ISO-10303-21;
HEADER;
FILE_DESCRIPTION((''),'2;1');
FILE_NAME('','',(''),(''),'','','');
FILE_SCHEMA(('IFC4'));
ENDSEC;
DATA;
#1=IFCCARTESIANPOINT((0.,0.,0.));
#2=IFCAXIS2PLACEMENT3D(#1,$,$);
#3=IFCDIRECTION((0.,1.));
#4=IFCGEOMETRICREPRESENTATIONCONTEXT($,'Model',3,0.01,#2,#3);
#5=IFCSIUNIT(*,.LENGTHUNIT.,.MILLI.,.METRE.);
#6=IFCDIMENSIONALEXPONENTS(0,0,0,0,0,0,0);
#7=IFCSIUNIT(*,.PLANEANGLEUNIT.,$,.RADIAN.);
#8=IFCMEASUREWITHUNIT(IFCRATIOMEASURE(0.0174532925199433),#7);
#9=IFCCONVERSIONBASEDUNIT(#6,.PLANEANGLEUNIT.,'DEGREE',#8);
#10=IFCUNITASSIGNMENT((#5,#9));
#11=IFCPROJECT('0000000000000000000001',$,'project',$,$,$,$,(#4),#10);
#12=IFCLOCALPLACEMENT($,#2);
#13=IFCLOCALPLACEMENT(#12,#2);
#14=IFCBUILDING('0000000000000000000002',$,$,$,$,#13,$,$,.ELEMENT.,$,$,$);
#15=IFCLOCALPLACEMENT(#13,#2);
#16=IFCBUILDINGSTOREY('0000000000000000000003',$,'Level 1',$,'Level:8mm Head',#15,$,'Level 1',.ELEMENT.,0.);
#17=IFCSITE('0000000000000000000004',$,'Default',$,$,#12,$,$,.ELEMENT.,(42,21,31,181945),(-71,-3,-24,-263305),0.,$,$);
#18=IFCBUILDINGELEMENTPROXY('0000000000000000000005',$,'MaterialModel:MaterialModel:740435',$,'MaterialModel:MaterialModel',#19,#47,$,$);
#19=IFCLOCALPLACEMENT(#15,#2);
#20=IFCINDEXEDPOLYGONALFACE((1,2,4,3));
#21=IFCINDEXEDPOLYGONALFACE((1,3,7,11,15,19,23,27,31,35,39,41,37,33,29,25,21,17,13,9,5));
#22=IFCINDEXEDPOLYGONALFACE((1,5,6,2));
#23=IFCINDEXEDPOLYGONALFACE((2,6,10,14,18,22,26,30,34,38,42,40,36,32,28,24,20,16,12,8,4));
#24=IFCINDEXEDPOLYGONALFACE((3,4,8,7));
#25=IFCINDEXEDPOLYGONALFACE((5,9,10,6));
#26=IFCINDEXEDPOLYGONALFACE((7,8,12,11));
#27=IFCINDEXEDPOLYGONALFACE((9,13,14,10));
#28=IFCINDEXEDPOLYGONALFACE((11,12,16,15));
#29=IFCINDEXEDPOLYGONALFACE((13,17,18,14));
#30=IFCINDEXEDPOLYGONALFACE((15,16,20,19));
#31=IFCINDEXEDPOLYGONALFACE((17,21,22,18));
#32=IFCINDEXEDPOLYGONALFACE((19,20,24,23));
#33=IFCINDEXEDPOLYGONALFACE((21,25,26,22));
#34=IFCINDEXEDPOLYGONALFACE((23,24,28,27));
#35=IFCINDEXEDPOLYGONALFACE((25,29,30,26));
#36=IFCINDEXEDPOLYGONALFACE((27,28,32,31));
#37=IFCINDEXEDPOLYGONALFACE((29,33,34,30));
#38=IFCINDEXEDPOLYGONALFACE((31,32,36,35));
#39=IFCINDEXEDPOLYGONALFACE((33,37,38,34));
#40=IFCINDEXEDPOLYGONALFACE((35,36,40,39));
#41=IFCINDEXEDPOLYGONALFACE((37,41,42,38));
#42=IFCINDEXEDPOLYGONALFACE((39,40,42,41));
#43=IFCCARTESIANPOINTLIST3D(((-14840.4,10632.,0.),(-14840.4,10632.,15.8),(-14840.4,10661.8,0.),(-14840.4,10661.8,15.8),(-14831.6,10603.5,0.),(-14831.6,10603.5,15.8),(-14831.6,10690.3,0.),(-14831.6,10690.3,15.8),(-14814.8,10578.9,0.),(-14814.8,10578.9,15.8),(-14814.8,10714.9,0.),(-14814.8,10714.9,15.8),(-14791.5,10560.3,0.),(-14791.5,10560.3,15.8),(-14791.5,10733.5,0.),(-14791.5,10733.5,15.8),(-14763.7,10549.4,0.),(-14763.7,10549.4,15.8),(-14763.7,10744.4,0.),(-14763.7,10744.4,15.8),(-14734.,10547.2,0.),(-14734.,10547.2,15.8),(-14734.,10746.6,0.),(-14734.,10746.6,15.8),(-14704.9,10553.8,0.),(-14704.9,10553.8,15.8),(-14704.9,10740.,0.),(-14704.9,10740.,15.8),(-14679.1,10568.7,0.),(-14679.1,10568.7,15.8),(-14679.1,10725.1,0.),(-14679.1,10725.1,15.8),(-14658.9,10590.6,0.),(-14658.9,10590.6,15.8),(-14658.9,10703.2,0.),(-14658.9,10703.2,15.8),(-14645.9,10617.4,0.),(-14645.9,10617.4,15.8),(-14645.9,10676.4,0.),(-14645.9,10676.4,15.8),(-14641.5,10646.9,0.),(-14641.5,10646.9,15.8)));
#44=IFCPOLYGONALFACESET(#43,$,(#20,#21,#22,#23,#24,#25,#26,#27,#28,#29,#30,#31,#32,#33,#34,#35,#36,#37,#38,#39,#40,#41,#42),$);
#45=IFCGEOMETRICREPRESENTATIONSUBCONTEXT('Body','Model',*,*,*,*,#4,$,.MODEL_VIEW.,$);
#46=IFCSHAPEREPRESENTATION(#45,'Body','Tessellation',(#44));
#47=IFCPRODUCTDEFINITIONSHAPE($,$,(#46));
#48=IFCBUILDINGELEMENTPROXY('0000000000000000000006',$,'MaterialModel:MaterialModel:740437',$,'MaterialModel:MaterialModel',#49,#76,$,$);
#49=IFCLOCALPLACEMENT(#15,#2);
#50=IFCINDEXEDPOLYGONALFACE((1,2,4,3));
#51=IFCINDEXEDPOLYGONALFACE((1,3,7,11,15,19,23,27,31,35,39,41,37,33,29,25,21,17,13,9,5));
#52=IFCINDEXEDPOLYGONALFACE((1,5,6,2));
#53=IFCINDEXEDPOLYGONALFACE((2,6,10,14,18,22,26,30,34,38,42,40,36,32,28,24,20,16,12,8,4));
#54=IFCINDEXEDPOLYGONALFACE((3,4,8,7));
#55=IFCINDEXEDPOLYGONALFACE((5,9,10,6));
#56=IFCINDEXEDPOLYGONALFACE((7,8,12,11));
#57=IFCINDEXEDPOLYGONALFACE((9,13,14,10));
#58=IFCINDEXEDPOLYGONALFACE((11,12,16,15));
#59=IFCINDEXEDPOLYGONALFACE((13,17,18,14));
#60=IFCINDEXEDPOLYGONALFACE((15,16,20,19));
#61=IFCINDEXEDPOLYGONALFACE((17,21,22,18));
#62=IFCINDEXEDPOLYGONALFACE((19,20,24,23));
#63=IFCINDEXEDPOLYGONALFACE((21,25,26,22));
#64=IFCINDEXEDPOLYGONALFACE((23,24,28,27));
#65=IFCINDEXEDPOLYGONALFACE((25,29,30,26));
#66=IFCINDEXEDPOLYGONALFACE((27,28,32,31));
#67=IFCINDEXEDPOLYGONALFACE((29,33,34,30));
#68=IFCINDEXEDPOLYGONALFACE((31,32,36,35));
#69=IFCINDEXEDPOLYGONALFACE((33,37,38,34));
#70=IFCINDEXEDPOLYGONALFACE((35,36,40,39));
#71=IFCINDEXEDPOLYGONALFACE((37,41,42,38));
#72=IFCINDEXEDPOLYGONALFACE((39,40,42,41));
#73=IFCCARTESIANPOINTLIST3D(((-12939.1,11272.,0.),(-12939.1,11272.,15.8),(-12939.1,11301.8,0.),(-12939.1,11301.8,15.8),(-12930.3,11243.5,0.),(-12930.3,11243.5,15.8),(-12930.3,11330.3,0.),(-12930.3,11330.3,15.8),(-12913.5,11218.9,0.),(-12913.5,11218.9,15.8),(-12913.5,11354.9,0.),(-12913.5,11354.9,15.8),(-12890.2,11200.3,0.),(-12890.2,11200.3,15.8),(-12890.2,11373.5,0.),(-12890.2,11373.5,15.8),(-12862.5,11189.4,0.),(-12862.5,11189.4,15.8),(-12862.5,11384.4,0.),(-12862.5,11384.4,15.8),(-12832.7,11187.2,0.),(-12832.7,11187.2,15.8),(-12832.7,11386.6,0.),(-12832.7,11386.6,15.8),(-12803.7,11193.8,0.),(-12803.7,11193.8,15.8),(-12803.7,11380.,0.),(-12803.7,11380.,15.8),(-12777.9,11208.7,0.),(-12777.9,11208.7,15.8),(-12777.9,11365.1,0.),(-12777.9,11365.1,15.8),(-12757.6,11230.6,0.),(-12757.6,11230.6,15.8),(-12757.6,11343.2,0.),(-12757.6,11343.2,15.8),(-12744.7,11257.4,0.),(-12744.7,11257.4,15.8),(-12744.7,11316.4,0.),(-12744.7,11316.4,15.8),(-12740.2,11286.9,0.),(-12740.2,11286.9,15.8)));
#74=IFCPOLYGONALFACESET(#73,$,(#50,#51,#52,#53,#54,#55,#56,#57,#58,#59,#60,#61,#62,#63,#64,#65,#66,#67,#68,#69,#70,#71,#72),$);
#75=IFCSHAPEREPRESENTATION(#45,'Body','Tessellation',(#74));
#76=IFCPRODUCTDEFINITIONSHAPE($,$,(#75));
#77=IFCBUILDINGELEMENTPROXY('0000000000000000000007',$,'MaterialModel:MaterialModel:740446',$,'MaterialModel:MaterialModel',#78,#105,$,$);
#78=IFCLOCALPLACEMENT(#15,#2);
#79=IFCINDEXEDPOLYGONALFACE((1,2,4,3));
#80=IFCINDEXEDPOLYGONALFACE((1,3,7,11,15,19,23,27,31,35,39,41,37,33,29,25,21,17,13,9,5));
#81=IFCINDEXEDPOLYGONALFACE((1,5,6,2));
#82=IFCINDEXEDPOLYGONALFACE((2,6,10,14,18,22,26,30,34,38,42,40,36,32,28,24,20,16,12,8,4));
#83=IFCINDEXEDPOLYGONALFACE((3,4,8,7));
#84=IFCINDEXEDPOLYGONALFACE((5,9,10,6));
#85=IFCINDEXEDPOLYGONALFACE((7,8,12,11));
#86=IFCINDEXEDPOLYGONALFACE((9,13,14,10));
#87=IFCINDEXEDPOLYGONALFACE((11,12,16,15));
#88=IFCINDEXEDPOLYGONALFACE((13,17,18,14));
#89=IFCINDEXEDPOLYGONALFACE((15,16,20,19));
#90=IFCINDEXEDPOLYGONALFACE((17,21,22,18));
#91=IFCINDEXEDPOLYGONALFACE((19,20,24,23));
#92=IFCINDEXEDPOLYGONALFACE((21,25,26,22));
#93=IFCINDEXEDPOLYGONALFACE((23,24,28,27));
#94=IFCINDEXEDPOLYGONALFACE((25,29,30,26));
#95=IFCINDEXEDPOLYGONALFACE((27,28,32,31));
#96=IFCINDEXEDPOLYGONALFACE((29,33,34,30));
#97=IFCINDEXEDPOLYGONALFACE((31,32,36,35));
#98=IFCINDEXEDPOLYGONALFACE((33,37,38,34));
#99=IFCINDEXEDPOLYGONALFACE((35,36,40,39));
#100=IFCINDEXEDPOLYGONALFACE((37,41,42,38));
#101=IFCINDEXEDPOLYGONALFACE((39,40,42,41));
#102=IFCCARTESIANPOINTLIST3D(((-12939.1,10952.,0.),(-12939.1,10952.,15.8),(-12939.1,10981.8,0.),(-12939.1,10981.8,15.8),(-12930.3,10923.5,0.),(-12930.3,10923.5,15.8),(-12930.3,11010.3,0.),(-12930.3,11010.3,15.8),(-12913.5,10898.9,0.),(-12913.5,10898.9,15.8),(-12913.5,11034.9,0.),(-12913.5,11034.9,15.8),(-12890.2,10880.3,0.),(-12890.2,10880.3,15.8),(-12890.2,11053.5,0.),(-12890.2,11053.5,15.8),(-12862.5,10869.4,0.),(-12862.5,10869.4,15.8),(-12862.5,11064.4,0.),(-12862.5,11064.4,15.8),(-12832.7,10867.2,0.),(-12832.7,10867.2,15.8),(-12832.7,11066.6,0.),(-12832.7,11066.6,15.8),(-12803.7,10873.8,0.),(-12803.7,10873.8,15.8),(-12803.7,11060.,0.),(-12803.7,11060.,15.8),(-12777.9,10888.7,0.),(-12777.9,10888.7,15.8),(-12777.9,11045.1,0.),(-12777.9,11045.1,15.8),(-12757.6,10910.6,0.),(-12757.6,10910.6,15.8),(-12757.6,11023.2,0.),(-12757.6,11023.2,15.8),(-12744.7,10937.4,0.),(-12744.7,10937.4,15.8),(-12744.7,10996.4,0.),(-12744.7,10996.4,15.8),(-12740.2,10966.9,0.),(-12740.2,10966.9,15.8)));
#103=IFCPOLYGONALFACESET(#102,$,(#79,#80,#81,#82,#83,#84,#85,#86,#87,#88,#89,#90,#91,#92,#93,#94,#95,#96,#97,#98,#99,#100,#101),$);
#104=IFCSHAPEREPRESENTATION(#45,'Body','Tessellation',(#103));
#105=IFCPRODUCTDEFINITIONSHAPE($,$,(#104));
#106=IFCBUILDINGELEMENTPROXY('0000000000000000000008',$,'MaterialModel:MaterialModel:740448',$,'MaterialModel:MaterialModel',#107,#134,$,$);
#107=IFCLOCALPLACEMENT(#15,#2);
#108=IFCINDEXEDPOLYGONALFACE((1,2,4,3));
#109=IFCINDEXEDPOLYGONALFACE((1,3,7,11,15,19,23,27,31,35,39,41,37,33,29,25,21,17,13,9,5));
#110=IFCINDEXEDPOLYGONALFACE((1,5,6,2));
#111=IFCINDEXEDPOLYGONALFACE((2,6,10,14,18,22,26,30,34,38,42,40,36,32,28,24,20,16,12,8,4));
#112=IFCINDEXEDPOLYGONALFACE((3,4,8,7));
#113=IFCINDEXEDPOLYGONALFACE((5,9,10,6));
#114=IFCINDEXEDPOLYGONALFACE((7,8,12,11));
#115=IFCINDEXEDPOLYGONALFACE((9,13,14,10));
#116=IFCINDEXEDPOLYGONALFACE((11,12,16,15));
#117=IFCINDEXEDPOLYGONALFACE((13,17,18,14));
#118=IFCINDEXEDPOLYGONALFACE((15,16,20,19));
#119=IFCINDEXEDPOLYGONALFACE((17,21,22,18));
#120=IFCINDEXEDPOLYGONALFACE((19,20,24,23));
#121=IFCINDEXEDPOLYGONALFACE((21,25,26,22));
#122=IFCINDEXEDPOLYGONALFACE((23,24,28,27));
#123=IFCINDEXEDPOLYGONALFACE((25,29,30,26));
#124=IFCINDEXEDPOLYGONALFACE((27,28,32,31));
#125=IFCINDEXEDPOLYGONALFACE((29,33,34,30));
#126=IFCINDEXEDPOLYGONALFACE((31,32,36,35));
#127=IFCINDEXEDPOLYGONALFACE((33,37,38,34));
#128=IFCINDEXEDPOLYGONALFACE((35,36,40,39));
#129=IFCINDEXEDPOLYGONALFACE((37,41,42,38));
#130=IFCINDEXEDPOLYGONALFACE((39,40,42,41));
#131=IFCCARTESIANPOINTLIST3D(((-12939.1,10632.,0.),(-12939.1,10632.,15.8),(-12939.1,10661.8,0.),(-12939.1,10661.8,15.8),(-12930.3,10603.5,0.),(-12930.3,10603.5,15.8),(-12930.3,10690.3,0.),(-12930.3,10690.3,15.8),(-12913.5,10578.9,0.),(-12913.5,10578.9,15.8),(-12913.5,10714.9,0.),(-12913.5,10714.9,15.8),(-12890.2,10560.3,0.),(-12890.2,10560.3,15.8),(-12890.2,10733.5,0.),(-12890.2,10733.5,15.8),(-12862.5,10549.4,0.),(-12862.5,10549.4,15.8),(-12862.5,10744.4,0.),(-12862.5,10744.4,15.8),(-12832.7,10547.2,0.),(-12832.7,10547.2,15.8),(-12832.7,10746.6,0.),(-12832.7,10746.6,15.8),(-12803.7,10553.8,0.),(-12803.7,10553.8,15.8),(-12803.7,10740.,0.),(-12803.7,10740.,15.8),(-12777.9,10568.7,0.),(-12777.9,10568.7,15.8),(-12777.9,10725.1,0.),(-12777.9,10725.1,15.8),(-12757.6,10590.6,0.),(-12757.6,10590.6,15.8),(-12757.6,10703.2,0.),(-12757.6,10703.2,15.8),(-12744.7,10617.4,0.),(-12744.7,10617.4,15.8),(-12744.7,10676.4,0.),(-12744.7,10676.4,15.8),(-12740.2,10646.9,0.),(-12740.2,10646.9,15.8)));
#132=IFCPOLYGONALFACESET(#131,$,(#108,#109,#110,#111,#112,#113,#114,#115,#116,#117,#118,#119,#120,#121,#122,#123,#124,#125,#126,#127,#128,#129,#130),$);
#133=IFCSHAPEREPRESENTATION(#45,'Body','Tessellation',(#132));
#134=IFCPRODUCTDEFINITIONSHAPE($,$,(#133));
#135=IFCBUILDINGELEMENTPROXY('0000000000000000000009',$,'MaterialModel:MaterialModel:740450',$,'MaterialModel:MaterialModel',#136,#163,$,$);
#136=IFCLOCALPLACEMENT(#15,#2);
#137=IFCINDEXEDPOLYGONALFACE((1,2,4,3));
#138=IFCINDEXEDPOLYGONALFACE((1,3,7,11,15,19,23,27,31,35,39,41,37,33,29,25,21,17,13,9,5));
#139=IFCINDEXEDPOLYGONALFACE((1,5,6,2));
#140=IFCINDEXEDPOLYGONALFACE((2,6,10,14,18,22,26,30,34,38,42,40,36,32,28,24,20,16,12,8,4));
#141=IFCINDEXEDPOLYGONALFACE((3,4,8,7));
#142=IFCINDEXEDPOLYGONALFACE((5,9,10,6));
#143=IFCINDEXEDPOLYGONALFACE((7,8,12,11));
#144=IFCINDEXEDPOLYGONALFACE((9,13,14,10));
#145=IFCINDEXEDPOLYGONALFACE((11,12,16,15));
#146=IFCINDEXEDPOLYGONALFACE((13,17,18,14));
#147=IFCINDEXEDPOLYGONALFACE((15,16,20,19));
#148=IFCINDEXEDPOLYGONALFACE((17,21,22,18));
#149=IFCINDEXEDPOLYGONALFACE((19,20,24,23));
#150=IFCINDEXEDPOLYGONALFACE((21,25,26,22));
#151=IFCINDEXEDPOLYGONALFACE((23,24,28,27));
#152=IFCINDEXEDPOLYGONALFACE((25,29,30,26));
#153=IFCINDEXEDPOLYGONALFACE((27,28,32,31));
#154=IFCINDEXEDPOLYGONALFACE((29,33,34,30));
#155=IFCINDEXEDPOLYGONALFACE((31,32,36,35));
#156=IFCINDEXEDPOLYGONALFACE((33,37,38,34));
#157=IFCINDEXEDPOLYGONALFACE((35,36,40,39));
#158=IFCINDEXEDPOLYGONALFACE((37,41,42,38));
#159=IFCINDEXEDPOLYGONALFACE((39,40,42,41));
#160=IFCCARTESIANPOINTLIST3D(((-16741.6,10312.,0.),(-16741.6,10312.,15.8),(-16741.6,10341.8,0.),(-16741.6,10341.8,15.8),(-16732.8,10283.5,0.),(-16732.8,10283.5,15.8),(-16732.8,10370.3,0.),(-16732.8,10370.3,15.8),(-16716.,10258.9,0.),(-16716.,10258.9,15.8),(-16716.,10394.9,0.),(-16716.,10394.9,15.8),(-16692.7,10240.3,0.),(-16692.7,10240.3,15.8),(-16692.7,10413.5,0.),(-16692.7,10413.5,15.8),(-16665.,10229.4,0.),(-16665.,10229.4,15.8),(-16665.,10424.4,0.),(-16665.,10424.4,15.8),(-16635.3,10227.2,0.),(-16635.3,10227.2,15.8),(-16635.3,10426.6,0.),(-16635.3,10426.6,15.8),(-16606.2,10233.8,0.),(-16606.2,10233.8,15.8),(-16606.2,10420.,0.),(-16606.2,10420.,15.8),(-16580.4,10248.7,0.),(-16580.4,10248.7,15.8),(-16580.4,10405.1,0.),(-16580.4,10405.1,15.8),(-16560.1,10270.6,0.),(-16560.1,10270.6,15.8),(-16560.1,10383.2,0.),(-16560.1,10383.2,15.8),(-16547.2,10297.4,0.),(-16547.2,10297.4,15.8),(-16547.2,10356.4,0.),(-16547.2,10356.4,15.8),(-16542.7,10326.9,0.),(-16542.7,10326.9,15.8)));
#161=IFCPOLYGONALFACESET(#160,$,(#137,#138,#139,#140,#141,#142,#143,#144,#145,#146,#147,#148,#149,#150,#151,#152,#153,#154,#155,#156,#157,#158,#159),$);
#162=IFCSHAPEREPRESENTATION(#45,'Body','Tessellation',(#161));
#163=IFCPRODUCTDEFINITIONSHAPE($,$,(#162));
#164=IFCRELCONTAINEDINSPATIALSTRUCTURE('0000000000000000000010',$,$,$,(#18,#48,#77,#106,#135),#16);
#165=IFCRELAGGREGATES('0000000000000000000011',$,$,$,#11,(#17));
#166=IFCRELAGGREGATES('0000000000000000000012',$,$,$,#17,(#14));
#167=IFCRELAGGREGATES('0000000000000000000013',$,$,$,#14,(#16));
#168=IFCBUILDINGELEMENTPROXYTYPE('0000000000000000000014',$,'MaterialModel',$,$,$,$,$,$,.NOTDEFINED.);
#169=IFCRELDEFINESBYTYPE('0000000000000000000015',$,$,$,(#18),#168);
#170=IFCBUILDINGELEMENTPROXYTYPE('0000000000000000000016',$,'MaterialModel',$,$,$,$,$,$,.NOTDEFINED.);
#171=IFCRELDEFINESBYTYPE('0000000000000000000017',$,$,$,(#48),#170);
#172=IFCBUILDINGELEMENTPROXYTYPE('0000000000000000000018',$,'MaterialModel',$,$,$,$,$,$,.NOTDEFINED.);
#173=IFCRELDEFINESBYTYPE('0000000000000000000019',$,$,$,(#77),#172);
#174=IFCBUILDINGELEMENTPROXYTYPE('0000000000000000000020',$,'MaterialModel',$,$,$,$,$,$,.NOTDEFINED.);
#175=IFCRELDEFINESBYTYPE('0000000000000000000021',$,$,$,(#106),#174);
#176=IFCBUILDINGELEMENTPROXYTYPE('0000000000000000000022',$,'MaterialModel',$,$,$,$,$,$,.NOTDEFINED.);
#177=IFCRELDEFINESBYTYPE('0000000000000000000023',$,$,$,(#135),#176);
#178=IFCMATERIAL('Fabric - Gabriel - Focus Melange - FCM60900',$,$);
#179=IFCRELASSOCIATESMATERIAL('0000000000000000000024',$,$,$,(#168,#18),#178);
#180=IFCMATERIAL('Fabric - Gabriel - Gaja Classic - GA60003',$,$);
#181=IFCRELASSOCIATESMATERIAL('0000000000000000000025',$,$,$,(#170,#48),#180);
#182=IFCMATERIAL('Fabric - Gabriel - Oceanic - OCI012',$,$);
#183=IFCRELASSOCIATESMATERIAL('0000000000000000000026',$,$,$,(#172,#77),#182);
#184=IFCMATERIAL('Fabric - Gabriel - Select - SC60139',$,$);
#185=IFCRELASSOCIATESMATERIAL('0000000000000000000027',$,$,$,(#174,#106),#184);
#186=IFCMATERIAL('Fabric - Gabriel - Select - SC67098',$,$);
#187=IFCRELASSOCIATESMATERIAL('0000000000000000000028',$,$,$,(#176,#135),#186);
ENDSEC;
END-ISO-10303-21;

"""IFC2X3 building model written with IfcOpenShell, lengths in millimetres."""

from ifc_helpers import new_model, entity, si_unit, converted_unit, direction, frame, frame_2d, origin, place, context, subcontext, project, spatial, circle, extrude, source, transform, mapped, material, type_object, type_shapes, element, save


model = new_model("IFC2X3")

# Units and contexts
model_context = context("Model", 3, precision=0.01, world=origin(), true_north=direction((0.0, 1.0)))
body_context = subcontext(model_context, "Body", "Model", "MODEL_VIEW")
ifc_project = project(units=[si_unit("LENGTHUNIT", "METRE", prefix="MILLI"), converted_unit("PLANEANGLEUNIT", "DEGREE", entity("IfcRatioMeasure", 0.0174532925199433), si_unit("PLANEANGLEUNIT", "RADIAN"), dimensions=[0, 0, 0, 0, 0, 0, 0])], contexts=[model_context])

# Site, building, storey
site_placement = place(None, origin())
site = spatial("IfcSite", under=ifc_project, at=site_placement, Name="Default", CompositionType="ELEMENT", RefLatitude=(42, 21, 31, 181945), RefLongitude=(-71, -3, -24, -263305), RefElevation=0.0)
building_placement = place(site_placement, origin())
building = spatial("IfcBuilding", under=site, at=building_placement, CompositionType="ELEMENT")
storey_placement = place(building_placement, origin())
storey = spatial("IfcBuildingStorey", under=building, at=storey_placement, Name="Level 1", ObjectType="Level:8mm Head", LongName="Level 1", CompositionType="ELEMENT", Elevation=0.0)

# Building element proxies
ifc_material_1 = material(Name="Fabric - Gabriel - Focus Melange - FCM60900")
building_element_proxy_type_1 = type_object("IfcBuildingElementProxyType", Name="MaterialModel", PredefinedType="NOTDEFINED", material=ifc_material_1)
shared_shape_1 = source(origin(), body_context, "Body", "SweptSolid", [
    extrude(circle(Radius=100.0, at=frame_2d((0.0, 0.0), x_axis=(1.0, 0.0))), origin(), (0.0, 0.0, 1.0), 15.8),
])
type_shapes(building_element_proxy_type_1, [shared_shape_1])
proxy_1_placement = place(storey_placement, frame((-14741.5, 10646.9, 0.0)))
element("IfcBuildingElementProxy", 1, at=proxy_1_placement, inside=storey, type_object=building_element_proxy_type_1, material=ifc_material_1, Name="MaterialModel:MaterialModel:740435", ObjectType="MaterialModel:MaterialModel", context=body_context, shape_type="MappedRepresentation", body=[
    mapped(shared_shape_1, transform((0.0, 0.0, 0.0), scale=1.0)),
])
ifc_material_2 = material(Name="Fabric - Gabriel - Gaja Classic - GA60003")
building_element_proxy_type_2 = type_object("IfcBuildingElementProxyType", Name="MaterialModel", PredefinedType="NOTDEFINED", material=ifc_material_2)
shared_shape_2 = source(origin(), body_context, "Body", "SweptSolid", [
    extrude(circle(Radius=100.0, at=frame_2d((0.0, 0.0), x_axis=(1.0, 0.0))), origin(), (0.0, 0.0, 1.0), 15.8),
])
type_shapes(building_element_proxy_type_2, [shared_shape_2])
proxy_2_placement = place(storey_placement, frame((-12840.2, 11286.9, 0.0)))
element("IfcBuildingElementProxy", 2, at=proxy_2_placement, inside=storey, type_object=building_element_proxy_type_2, material=ifc_material_2, Name="MaterialModel:MaterialModel:740437", ObjectType="MaterialModel:MaterialModel", context=body_context, shape_type="MappedRepresentation", body=[
    mapped(shared_shape_2, transform((0.0, 0.0, 0.0), scale=1.0)),
])
ifc_material_3 = material(Name="Fabric - Gabriel - Oceanic - OCI012")
building_element_proxy_type_3 = type_object("IfcBuildingElementProxyType", Name="MaterialModel", PredefinedType="NOTDEFINED", material=ifc_material_3)
shared_shape_3 = source(origin(), body_context, "Body", "SweptSolid", [
    extrude(circle(Radius=100.0, at=frame_2d((0.0, 0.0), x_axis=(1.0, 0.0))), origin(), (0.0, 0.0, 1.0), 15.8),
])
type_shapes(building_element_proxy_type_3, [shared_shape_3])
proxy_3_placement = place(storey_placement, frame((-12840.2, 10966.9, 0.0)))
element("IfcBuildingElementProxy", 3, at=proxy_3_placement, inside=storey, type_object=building_element_proxy_type_3, material=ifc_material_3, Name="MaterialModel:MaterialModel:740446", ObjectType="MaterialModel:MaterialModel", context=body_context, shape_type="MappedRepresentation", body=[
    mapped(shared_shape_3, transform((0.0, 0.0, 0.0), scale=1.0)),
])
ifc_material_4 = material(Name="Fabric - Gabriel - Select - SC60139")
building_element_proxy_type_4 = type_object("IfcBuildingElementProxyType", Name="MaterialModel", PredefinedType="NOTDEFINED", material=ifc_material_4)
shared_shape_4 = source(origin(), body_context, "Body", "SweptSolid", [
    extrude(circle(Radius=100.0, at=frame_2d((0.0, 0.0), x_axis=(1.0, 0.0))), origin(), (0.0, 0.0, 1.0), 15.8),
])
type_shapes(building_element_proxy_type_4, [shared_shape_4])
proxy_4_placement = place(storey_placement, frame((-12840.2, 10646.9, 0.0)))
element("IfcBuildingElementProxy", 4, at=proxy_4_placement, inside=storey, type_object=building_element_proxy_type_4, material=ifc_material_4, Name="MaterialModel:MaterialModel:740448", ObjectType="MaterialModel:MaterialModel", context=body_context, shape_type="MappedRepresentation", body=[
    mapped(shared_shape_4, transform((0.0, 0.0, 0.0), scale=1.0)),
])
ifc_material_5 = material(Name="Fabric - Gabriel - Select - SC67098")
building_element_proxy_type_5 = type_object("IfcBuildingElementProxyType", Name="MaterialModel", PredefinedType="NOTDEFINED", material=ifc_material_5)
shared_shape_5 = source(origin(), body_context, "Body", "SweptSolid", [
    extrude(circle(Radius=100.0, at=frame_2d((0.0, 0.0), x_axis=(1.0, 0.0))), origin(), (0.0, 0.0, 1.0), 15.8),
])
type_shapes(building_element_proxy_type_5, [shared_shape_5])
proxy_5_placement = place(storey_placement, frame((-16642.7, 10326.9, 0.0)))
element("IfcBuildingElementProxy", 5, at=proxy_5_placement, inside=storey, type_object=building_element_proxy_type_5, material=ifc_material_5, Name="MaterialModel:MaterialModel:740450", ObjectType="MaterialModel:MaterialModel", context=body_context, shape_type="MappedRepresentation", body=[
    mapped(shared_shape_5, transform((0.0, 0.0, 0.0), scale=1.0)),
])

save(model, "model.ifc")
